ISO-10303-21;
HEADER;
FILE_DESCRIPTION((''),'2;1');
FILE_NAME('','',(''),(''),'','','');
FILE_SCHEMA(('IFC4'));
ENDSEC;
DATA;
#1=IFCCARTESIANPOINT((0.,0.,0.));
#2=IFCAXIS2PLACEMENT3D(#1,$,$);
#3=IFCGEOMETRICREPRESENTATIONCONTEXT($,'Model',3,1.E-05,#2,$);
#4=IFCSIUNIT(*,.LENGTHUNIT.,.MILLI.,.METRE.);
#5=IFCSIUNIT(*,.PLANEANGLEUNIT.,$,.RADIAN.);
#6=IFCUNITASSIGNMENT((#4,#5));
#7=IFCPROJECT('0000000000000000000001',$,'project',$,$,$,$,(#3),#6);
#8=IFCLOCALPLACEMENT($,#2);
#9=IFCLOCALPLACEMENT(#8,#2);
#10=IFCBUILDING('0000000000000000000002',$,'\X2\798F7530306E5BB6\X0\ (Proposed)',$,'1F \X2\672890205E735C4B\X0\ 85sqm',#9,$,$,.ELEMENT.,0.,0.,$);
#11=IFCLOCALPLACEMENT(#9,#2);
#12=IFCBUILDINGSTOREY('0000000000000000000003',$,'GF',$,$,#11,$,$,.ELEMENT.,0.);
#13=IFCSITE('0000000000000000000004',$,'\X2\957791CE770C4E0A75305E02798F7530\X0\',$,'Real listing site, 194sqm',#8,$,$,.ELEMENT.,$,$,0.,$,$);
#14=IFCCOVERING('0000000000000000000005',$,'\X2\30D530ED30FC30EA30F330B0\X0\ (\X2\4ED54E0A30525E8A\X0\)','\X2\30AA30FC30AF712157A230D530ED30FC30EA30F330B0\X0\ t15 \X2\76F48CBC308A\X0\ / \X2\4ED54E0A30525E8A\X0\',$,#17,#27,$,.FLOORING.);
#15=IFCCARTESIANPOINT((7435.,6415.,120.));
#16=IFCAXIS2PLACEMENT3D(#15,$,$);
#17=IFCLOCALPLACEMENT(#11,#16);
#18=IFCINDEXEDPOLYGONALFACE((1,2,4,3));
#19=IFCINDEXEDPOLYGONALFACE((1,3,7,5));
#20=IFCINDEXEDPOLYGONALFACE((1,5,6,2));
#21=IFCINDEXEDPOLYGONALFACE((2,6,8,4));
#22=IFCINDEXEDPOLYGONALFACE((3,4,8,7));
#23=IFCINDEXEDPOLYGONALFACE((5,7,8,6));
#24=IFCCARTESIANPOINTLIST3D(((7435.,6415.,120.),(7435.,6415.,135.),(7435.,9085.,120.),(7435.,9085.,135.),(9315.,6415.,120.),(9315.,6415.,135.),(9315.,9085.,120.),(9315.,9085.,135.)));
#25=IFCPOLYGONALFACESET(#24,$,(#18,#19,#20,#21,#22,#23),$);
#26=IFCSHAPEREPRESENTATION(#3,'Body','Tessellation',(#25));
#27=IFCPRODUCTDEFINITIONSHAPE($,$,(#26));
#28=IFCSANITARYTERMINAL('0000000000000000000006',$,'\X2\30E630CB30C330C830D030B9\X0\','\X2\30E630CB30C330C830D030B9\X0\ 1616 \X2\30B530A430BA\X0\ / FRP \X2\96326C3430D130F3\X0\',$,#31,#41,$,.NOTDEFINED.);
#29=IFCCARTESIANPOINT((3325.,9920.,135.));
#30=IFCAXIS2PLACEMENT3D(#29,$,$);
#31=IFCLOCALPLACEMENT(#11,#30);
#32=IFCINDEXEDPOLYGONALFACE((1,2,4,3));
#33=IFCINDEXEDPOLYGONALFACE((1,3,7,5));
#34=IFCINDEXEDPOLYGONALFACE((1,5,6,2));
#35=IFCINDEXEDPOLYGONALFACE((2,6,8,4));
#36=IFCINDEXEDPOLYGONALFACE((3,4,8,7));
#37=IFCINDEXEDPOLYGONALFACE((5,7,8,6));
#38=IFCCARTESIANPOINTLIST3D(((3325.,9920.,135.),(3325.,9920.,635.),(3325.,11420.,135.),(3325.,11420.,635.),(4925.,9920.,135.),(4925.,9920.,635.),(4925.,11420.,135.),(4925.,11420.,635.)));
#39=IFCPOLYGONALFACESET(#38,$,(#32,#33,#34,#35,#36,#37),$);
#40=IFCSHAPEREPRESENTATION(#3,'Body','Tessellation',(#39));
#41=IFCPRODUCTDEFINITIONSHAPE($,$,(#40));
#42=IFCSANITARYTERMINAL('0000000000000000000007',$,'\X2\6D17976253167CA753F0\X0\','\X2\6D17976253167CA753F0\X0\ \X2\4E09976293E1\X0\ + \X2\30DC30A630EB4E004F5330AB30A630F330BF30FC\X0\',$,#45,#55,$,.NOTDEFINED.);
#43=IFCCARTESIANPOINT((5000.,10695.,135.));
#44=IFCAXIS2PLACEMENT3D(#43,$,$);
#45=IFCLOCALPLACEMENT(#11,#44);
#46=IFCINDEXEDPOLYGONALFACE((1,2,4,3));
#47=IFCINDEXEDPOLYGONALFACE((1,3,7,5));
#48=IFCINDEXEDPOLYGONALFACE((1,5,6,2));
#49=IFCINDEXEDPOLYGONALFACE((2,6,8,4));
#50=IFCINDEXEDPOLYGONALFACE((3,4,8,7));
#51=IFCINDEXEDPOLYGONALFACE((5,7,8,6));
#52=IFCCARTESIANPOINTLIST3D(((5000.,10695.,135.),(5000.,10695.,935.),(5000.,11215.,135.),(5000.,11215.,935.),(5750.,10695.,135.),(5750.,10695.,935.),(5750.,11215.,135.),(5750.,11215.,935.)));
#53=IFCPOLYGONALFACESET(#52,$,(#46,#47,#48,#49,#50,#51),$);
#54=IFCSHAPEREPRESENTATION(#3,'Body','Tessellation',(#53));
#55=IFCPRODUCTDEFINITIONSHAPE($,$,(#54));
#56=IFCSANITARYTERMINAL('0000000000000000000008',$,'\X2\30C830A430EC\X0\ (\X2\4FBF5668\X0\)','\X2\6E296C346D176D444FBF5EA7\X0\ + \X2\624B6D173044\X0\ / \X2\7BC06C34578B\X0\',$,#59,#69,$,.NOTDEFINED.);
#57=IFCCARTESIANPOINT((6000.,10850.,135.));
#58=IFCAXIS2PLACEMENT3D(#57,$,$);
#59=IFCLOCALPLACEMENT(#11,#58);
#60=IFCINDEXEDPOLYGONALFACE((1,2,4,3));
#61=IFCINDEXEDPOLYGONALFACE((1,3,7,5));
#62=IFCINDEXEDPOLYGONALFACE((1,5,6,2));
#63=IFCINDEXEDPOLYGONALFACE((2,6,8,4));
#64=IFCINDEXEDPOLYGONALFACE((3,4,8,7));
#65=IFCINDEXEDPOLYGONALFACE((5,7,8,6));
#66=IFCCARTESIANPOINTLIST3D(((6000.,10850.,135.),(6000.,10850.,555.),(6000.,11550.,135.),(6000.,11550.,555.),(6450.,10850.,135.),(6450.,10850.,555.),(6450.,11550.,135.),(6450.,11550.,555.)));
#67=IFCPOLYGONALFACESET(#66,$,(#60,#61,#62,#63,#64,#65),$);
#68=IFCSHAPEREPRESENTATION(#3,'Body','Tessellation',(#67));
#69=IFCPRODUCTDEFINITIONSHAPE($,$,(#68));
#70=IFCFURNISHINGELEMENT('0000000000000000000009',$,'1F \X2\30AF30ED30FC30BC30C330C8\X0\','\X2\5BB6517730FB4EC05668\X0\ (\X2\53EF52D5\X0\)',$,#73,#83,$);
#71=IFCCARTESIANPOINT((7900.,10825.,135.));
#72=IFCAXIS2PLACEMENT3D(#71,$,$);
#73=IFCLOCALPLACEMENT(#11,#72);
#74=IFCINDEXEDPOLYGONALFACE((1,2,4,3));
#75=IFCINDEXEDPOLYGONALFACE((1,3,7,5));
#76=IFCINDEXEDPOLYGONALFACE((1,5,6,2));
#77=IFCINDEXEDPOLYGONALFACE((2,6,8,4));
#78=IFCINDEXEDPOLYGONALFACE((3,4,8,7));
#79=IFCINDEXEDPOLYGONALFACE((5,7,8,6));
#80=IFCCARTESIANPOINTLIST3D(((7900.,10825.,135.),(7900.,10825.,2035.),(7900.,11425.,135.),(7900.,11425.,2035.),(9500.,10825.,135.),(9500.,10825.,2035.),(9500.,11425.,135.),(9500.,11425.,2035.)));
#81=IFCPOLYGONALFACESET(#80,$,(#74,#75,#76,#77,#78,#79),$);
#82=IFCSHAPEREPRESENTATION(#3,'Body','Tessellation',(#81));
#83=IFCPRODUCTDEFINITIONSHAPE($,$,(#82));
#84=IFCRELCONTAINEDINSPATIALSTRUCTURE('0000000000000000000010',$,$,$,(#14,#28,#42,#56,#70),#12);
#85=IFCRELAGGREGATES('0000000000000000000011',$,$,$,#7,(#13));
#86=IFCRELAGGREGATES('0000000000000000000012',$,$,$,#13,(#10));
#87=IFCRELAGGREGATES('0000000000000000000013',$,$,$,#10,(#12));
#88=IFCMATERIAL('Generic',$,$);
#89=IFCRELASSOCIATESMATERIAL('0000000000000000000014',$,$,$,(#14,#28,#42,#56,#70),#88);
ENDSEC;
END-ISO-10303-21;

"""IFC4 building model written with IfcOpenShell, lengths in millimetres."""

from ifc_helpers import new_model, si_unit, frame, frame_2d, origin, place, context, project, spatial, rectangle, extrude, material, element, save


model = new_model("IFC4")

# Units and contexts
model_context = context("Model", 3, precision=1e-05, world=origin())
ifc_project = project(units=[si_unit("LENGTHUNIT", "METRE", prefix="MILLI"), si_unit("PLANEANGLEUNIT", "RADIAN")], contexts=[model_context])

# Site, building, storey
site_placement = place(None, origin())
site = spatial("IfcSite", under=ifc_project, at=site_placement, Name="長野県上田市福田", ObjectType="Real listing site, 194sqm", CompositionType="ELEMENT", RefElevation=0.0)
building_placement = place(site_placement, origin())
building = spatial("IfcBuilding", under=site, at=building_placement, Name="福田の家 (Proposed)", ObjectType="1F 木造平屋 85sqm", CompositionType="ELEMENT", ElevationOfRefHeight=0.0, ElevationOfTerrain=0.0)
storey_placement = place(building_placement, origin())
storey = spatial("IfcBuildingStorey", under=building, at=storey_placement, Name="GF", CompositionType="ELEMENT", Elevation=0.0)

# Covering
ifc_material_1 = material(Name="Generic")
covering_1_placement = place(storey_placement, frame((7435.0, 6415.0, 120.0)))
element("IfcCovering", 1, at=covering_1_placement, inside=storey, material=ifc_material_1, Name="フローリング (仕上げ床)", Description="オーク無垢フローリング t15 直貼り / 仕上げ床", PredefinedType="FLOORING", context=model_context, shape_type="SweptSolid", body=[
    extrude(rectangle(XDim=1880.0, YDim=2670.0, at=frame_2d((940.0, 1335.0))), frame((7435.0, 6415.0, 120.0)), (0.0, 0.0, 1.0), 15.0),
])

# Sanitary terminals
sanitary_terminal_1_placement = place(storey_placement, frame((3325.0, 9920.0, 135.0)))
element("IfcSanitaryTerminal", 2, at=sanitary_terminal_1_placement, inside=storey, material=ifc_material_1, Name="ユニットバス", Description="ユニットバス 1616 サイズ / FRP 防水パン", PredefinedType="NOTDEFINED", context=model_context, shape_type="SweptSolid", body=[
    extrude(rectangle(XDim=1600.0, YDim=1500.0, at=frame_2d((800.0, 750.0))), frame((3325.0, 9920.0, 135.0)), (0.0, 0.0, 1.0), 500.0),
])
sanitary_terminal_2_placement = place(storey_placement, frame((5000.0, 10695.0, 135.0)))
element("IfcSanitaryTerminal", 3, at=sanitary_terminal_2_placement, inside=storey, material=ifc_material_1, Name="洗面化粧台", Description="洗面化粧台 三面鏡 + ボウル一体カウンター", PredefinedType="NOTDEFINED", context=model_context, shape_type="SweptSolid", body=[
    extrude(rectangle(XDim=750.0, YDim=520.0, at=frame_2d((375.0, 260.0))), frame((5000.0, 10695.0, 135.0)), (0.0, 0.0, 1.0), 800.0),
])
sanitary_terminal_3_placement = place(storey_placement, frame((6000.0, 10850.0, 135.0)))
element("IfcSanitaryTerminal", 4, at=sanitary_terminal_3_placement, inside=storey, material=ifc_material_1, Name="トイレ (便器)", Description="温水洗浄便座 + 手洗い / 節水型", PredefinedType="NOTDEFINED", context=model_context, shape_type="SweptSolid", body=[
    extrude(rectangle(XDim=450.0, YDim=700.0, at=frame_2d((225.0, 350.0))), frame((6000.0, 10850.0, 135.0)), (0.0, 0.0, 1.0), 420.0),
])

# Furnishing element
furnishing_placement = place(storey_placement, frame((7900.0, 10825.0, 135.0)))
element("IfcFurnishingElement", 5, at=furnishing_placement, inside=storey, material=ifc_material_1, Name="1F クローゼット", Description="家具・什器 (可動)", context=model_context, shape_type="SweptSolid", body=[
    extrude(rectangle(XDim=1600.0, YDim=600.0, at=frame_2d((800.0, 300.0))), frame((7900.0, 10825.0, 135.0)), (0.0, 0.0, 1.0), 1900.0),
])

save(model, "model.ifc")
